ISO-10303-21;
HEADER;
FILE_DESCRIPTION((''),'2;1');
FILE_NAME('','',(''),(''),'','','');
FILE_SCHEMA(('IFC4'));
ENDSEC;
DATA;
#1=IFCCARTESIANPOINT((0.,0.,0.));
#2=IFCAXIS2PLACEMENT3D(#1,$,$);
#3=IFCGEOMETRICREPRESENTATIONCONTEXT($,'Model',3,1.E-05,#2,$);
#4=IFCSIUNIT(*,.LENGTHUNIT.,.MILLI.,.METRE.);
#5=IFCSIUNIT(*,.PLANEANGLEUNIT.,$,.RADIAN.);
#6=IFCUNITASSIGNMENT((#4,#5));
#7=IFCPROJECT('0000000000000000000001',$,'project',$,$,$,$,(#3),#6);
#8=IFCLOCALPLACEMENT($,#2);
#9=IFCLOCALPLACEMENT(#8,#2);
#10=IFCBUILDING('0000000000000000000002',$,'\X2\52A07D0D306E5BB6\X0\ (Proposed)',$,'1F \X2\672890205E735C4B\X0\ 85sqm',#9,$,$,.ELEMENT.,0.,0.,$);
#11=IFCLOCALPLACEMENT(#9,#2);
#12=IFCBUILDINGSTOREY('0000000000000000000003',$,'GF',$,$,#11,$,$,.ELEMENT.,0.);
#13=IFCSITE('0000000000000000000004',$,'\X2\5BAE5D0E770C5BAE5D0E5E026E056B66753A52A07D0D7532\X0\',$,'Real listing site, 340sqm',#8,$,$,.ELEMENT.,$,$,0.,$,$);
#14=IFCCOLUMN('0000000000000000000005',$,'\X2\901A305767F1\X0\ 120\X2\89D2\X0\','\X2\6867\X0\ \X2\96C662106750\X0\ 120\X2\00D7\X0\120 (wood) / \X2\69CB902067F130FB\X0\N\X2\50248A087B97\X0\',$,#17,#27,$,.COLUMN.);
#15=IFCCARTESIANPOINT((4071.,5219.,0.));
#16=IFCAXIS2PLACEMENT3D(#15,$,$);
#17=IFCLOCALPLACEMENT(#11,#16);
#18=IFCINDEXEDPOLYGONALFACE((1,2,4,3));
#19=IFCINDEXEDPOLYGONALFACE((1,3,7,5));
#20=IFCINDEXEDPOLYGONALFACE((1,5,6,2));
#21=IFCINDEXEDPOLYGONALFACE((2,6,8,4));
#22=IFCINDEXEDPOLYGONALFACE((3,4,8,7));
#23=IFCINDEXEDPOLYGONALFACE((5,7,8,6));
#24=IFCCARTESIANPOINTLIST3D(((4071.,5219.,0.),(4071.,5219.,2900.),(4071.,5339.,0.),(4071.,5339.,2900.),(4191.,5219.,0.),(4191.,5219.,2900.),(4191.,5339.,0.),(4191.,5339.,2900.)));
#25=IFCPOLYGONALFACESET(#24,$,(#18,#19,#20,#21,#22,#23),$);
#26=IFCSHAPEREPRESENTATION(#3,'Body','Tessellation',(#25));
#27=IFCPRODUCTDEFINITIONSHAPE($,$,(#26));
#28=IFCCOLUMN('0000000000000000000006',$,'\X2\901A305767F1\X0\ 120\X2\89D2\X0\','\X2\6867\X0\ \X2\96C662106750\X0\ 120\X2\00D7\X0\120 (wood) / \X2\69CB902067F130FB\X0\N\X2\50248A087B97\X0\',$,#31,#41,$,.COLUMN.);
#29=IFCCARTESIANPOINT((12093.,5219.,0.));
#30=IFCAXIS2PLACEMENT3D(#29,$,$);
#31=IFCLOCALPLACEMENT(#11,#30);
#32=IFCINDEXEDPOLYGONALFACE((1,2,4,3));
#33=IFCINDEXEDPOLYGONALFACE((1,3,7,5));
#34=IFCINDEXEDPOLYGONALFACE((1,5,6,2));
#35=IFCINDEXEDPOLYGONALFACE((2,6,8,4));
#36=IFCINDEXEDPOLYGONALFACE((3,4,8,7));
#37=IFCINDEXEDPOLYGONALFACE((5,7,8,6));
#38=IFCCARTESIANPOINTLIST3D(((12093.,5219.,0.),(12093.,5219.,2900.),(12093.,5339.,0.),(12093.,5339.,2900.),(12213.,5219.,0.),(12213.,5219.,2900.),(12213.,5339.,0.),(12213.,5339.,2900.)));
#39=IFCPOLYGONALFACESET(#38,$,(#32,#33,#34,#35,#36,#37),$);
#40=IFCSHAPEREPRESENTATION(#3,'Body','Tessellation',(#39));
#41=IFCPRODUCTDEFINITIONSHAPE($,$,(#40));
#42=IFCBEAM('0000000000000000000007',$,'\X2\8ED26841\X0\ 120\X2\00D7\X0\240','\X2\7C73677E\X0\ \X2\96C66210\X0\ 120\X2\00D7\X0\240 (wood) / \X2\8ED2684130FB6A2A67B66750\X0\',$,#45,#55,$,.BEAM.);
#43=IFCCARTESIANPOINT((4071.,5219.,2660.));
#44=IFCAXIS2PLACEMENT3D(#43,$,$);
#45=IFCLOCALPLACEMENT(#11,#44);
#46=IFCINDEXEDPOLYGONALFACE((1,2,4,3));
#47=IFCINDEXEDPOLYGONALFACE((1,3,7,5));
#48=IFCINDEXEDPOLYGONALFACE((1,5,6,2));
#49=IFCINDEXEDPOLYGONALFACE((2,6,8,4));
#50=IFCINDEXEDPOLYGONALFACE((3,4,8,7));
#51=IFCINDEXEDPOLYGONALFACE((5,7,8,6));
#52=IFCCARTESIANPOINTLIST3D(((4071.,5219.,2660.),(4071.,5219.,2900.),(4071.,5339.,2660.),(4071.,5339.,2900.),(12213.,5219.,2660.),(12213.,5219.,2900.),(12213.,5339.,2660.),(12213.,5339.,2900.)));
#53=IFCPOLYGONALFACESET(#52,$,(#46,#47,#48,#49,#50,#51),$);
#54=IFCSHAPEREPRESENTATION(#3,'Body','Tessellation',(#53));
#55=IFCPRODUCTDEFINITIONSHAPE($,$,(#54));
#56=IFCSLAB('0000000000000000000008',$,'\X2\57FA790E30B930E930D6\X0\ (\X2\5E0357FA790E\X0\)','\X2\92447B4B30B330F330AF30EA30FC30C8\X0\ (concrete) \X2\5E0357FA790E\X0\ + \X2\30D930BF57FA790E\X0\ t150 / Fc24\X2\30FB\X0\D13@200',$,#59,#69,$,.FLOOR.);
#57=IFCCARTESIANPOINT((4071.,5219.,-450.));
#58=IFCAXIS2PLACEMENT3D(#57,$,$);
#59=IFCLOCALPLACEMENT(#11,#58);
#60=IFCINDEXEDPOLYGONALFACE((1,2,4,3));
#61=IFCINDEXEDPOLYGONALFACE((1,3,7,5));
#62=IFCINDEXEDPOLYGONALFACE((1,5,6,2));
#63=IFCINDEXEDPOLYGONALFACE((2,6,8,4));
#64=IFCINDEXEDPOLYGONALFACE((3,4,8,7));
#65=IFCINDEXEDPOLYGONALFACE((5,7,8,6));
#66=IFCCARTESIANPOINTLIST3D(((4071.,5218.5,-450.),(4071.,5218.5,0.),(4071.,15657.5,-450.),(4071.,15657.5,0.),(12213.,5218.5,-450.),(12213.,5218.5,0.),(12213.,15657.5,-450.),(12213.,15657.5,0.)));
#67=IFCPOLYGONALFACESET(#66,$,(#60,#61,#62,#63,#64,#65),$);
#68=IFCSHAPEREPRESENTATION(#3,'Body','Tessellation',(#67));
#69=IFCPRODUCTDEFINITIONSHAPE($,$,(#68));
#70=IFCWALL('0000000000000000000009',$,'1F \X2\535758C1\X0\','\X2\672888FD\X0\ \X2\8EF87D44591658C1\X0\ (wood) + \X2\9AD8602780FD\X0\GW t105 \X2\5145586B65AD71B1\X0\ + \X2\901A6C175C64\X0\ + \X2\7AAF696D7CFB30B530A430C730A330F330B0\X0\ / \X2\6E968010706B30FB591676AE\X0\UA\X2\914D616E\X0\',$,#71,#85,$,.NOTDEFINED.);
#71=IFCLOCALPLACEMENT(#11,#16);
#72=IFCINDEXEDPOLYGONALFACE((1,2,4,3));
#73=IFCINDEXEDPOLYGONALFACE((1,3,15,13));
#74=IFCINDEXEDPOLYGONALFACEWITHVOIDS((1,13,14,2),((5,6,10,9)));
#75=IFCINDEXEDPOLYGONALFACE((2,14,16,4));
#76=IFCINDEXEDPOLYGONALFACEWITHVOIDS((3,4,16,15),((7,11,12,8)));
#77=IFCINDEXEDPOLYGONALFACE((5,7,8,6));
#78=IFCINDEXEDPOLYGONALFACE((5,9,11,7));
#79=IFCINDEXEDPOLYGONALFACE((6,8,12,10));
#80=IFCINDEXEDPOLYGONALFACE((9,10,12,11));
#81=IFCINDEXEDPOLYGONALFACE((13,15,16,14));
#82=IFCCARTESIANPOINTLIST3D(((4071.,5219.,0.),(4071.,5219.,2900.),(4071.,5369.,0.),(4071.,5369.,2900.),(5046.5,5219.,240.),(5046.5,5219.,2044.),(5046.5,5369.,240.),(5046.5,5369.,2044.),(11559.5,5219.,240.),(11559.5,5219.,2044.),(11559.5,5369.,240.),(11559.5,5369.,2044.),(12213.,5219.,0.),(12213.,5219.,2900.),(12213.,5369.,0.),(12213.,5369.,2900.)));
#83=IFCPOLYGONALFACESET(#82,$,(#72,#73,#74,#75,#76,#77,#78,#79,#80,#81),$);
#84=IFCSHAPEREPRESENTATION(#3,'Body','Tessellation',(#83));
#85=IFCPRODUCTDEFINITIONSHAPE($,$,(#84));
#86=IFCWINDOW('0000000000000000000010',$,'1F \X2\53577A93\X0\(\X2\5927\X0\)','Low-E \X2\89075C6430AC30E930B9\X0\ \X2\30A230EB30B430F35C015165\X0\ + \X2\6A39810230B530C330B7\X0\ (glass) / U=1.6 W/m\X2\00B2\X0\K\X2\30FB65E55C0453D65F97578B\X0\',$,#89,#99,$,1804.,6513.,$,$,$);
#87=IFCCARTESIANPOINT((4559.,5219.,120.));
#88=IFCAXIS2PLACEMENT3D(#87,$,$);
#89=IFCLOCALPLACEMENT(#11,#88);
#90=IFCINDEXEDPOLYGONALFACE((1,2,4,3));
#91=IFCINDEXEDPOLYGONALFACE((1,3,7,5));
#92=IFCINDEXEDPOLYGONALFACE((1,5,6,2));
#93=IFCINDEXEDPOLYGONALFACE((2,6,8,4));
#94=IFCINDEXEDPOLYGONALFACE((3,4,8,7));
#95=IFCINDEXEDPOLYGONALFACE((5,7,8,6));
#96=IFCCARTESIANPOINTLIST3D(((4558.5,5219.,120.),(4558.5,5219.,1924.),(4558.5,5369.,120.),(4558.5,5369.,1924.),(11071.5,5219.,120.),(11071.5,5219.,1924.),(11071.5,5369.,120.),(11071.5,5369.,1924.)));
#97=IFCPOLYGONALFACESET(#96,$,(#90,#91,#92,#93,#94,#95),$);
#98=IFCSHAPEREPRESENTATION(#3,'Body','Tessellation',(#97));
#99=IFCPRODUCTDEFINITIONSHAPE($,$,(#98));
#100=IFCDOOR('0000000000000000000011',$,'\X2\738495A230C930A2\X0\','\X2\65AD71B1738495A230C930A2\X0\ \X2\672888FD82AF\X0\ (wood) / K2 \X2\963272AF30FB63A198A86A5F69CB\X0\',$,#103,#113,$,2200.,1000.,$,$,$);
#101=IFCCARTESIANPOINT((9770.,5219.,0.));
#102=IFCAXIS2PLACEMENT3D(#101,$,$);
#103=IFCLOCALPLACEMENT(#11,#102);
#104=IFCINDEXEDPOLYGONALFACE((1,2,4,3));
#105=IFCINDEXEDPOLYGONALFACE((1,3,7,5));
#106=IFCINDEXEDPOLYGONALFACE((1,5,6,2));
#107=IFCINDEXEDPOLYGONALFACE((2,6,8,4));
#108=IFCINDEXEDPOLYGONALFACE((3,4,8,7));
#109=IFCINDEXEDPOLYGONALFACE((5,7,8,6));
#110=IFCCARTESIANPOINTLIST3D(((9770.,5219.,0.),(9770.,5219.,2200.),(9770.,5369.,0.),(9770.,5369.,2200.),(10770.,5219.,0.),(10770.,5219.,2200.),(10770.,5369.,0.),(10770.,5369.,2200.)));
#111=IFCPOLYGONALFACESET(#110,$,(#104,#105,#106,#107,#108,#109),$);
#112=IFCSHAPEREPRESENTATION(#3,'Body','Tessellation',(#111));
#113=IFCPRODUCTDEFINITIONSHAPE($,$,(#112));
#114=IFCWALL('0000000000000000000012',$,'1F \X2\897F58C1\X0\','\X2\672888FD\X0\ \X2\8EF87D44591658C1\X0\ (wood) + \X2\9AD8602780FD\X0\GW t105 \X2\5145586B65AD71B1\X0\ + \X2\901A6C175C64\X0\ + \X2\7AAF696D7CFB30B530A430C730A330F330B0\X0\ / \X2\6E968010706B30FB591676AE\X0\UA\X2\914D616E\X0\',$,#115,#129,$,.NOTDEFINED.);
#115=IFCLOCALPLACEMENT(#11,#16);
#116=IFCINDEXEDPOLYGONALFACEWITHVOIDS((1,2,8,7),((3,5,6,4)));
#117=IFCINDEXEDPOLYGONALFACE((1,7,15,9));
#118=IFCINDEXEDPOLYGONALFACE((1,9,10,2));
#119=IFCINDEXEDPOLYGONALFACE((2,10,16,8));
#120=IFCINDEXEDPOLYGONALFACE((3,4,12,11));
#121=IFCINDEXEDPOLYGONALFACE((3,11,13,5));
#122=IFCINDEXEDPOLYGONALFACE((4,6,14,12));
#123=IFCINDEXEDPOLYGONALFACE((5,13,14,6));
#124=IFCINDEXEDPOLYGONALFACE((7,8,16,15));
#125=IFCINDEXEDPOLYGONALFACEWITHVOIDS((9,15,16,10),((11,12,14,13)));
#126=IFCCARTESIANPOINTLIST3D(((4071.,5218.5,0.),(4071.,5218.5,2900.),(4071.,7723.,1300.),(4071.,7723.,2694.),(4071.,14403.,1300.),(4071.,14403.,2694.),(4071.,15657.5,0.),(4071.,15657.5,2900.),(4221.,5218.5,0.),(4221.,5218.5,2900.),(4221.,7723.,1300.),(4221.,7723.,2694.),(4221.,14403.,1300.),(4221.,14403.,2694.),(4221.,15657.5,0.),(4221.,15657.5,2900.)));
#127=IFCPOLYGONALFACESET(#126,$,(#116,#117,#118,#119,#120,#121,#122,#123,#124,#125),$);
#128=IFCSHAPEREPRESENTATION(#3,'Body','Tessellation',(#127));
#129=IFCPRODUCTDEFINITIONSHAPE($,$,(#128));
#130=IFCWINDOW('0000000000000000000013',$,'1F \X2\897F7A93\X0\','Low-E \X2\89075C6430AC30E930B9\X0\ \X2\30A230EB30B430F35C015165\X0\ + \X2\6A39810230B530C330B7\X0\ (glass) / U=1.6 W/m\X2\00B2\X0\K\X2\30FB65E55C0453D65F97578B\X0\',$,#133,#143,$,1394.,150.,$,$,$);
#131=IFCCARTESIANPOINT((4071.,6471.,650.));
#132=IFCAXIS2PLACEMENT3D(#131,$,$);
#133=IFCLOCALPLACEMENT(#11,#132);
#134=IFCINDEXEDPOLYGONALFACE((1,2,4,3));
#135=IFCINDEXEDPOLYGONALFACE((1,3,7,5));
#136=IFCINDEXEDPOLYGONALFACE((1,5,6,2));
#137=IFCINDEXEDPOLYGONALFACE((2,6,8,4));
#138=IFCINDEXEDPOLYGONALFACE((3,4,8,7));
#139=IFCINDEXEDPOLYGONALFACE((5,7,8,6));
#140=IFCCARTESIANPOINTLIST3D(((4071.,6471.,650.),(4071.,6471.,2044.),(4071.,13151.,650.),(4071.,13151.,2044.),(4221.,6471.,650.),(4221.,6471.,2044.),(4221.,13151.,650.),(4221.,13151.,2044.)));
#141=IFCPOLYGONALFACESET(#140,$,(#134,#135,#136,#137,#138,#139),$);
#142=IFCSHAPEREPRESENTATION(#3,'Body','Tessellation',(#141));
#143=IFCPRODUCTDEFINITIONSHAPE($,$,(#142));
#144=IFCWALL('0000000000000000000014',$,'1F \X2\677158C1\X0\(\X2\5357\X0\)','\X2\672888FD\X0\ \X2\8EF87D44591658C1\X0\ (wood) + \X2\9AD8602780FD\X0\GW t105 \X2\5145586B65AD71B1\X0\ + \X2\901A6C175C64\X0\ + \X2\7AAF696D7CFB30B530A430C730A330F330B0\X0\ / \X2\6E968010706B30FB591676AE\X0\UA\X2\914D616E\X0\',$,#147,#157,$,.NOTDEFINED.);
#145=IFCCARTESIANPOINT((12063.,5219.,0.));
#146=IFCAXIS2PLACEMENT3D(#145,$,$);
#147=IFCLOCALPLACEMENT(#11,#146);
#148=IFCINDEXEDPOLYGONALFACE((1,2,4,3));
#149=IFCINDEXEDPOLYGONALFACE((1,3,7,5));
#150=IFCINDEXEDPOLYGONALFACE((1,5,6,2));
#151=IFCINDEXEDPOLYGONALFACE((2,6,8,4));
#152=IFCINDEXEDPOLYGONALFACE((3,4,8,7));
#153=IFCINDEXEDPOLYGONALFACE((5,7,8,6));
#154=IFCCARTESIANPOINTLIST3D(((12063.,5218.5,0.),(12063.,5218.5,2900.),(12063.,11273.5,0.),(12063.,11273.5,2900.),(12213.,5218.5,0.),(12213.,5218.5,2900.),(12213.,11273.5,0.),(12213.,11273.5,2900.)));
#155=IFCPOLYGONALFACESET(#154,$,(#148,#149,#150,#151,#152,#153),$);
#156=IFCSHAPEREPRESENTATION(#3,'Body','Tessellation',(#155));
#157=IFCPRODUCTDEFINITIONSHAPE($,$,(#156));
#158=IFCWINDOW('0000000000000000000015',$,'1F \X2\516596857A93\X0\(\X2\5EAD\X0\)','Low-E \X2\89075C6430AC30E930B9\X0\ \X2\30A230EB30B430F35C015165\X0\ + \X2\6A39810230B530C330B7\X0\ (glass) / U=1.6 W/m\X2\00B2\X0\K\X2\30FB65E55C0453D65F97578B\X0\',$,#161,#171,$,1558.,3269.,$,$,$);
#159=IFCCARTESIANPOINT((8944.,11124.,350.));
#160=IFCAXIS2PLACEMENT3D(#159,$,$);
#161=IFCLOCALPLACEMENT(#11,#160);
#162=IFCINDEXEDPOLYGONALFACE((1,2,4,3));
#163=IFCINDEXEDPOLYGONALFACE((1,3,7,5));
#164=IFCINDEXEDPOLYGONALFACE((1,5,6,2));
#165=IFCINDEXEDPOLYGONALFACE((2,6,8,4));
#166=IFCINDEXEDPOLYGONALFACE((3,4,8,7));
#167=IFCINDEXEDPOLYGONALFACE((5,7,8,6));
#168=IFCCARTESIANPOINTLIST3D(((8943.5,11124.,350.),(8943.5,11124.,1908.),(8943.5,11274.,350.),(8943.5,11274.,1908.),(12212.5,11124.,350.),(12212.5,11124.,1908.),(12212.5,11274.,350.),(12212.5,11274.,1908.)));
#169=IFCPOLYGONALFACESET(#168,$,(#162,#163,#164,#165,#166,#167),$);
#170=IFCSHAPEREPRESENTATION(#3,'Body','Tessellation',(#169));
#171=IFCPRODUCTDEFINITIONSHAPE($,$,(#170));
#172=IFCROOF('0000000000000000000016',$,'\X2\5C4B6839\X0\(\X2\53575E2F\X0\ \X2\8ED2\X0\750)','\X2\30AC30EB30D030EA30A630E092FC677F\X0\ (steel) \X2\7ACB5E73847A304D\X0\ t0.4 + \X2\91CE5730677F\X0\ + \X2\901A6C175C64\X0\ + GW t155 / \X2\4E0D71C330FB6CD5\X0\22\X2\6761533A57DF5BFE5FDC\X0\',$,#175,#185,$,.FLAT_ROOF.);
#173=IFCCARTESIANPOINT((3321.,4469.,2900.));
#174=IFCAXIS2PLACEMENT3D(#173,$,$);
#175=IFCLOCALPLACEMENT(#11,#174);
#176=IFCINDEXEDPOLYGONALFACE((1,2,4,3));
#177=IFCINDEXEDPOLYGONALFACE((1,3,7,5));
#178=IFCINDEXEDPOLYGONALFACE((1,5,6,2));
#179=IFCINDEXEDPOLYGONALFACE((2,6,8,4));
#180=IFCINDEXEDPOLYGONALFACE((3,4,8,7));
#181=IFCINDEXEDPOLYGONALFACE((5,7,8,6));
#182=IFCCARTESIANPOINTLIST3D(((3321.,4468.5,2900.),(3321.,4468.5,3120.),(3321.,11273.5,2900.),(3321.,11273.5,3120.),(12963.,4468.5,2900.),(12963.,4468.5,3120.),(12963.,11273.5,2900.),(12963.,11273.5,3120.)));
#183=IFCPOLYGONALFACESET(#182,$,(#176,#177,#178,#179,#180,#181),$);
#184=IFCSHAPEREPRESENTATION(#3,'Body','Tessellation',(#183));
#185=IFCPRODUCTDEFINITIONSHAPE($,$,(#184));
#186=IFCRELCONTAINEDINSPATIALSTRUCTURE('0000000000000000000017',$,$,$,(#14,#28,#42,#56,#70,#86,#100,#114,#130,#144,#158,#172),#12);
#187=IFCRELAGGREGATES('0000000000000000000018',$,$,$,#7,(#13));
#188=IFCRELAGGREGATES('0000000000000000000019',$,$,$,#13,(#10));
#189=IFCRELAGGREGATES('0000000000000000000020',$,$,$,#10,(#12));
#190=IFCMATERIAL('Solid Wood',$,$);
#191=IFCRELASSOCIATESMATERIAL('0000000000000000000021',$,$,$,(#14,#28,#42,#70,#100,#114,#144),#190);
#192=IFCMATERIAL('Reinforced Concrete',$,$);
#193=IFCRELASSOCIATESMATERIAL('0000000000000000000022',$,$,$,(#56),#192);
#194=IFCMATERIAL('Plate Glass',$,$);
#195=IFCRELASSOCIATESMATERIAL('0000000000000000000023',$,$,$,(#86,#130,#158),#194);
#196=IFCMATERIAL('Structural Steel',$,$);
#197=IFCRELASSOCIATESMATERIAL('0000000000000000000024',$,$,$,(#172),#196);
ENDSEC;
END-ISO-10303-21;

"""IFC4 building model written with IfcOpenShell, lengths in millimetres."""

from ifc_helpers import new_model, si_unit, frame, frame_2d, origin, place, context, project, spatial, rectangle, extrude, material, element, fill, save


model = new_model("IFC4")

# Units and contexts
model_context = context("Model", 3, precision=1e-05, world=origin())
ifc_project = project(units=[si_unit("LENGTHUNIT", "METRE", prefix="MILLI"), si_unit("PLANEANGLEUNIT", "RADIAN")], contexts=[model_context])

# Site, building, storey
site_placement = place(None, origin())
site = spatial("IfcSite", under=ifc_project, at=site_placement, Name="宮崎県宮崎市清武町加納甲", ObjectType="Real listing site, 340sqm", CompositionType="ELEMENT", RefElevation=0.0)
building_placement = place(site_placement, origin())
building = spatial("IfcBuilding", under=site, at=building_placement, Name="加納の家 (Proposed)", ObjectType="1F 木造平屋 85sqm", CompositionType="ELEMENT", ElevationOfRefHeight=0.0, ElevationOfTerrain=0.0)
storey_placement = place(building_placement, origin())
storey = spatial("IfcBuildingStorey", under=building, at=storey_placement, Name="GF", CompositionType="ELEMENT", Elevation=0.0)

# Columns
ifc_material_1 = material(Name="Solid Wood")
column_1_placement = place(storey_placement, frame((4071.0, 5219.0, 0.0)))
element("IfcColumn", 1, at=column_1_placement, inside=storey, material=ifc_material_1, Name="通し柱 120角", Description="桧 集成材 120×120 (wood) / 構造柱・N値計算", PredefinedType="COLUMN", context=model_context, shape_type="SweptSolid", body=[
    extrude(rectangle(XDim=120.0, YDim=120.0, at=frame_2d((60.0, 60.0))), frame((4071.0, 5219.0, 0.0)), (0.0, 0.0, 1.0), 2900.0),
])
column_2_placement = place(storey_placement, frame((12093.0, 5219.0, 0.0)))
element("IfcColumn", 2, at=column_2_placement, inside=storey, material=ifc_material_1, Name="通し柱 120角", Description="桧 集成材 120×120 (wood) / 構造柱・N値計算", PredefinedType="COLUMN", context=model_context, shape_type="SweptSolid", body=[
    extrude(rectangle(XDim=120.0, YDim=120.0, at=frame_2d((60.0, 60.0))), frame((12093.0, 5219.0, 0.0)), (0.0, 0.0, 1.0), 2900.0),
])

# Beam
beam_1_placement = place(storey_placement, frame((4071.0, 5219.0, 2660.0)))
element("IfcBeam", 3, at=beam_1_placement, inside=storey, material=ifc_material_1, Name="軒桁 120×240", Description="米松 集成 120×240 (wood) / 軒桁・横架材", PredefinedType="BEAM", context=model_context, shape_type="SweptSolid", body=[
    extrude(rectangle(XDim=8142.0, YDim=120.0, at=frame_2d((4071.0, 60.0))), frame((4071.0, 5219.0, 2660.0)), (0.0, 0.0, 1.0), 240.0),
])

# Slab
ifc_material_2 = material(Name="Reinforced Concrete")
slab_1_placement = place(storey_placement, frame((4071.0, 5219.0, -450.0)))
element("IfcSlab", 4, at=slab_1_placement, inside=storey, material=ifc_material_2, Name="基礎スラブ (布基礎)", Description="鉄筋コンクリート (concrete) 布基礎 + ベタ基礎 t150 / Fc24・D13@200", PredefinedType="FLOOR", context=model_context, shape_type="SweptSolid", body=[
    extrude(rectangle(XDim=8142.0, YDim=10439.0, at=frame_2d((4071.0, 5219.0))), frame((4071.0, 5219.0, -450.0)), (0.0, 0.0, 1.0), 450.0),
])

# Wall, openings, window, door
wall_1_placement = place(storey_placement, frame((4071.0, 5219.0, 0.0)))
wall_1 = element("IfcWall", 5, at=wall_1_placement, inside=storey, material=ifc_material_1, Name="1F 南壁", Description="木製 軸組外壁 (wood) + 高性能GW t105 充填断熱 + 通気層 + 窯業系サイディング / 準耐火・外皮UA配慮", PredefinedType="NOTDEFINED", context=model_context, shape_type="SweptSolid", body=[
    extrude(rectangle(XDim=8142.0, YDim=150.0, at=frame_2d((4071.0, 75.0))), frame((4071.0, 5219.0, 0.0)), (0.0, 0.0, 1.0), 2900.0),
])
opening_1_placement = place(storey_placement, frame((4559.0, 5219.0, 120.0)))
opening_1 = element("IfcOpeningElement", 6, at=opening_1_placement, cuts=wall_1, PredefinedType="NOTDEFINED", context=model_context, shape_type="SweptSolid", body=[
    extrude(rectangle(XDim=6513.0, YDim=150.0, at=frame_2d((3256.0, 75.0))), frame((4559.0, 5219.0, 120.0)), (0.0, 0.0, 1.0), 1804.0),
])
opening_2_placement = place(storey_placement, frame((9770.0, 5219.0, 0.0)))
opening_2 = element("IfcOpeningElement", 7, at=opening_2_placement, cuts=wall_1, PredefinedType="NOTDEFINED", context=model_context, shape_type="SweptSolid", body=[
    extrude(rectangle(XDim=1000.0, YDim=150.0, at=frame_2d((500.0, 75.0))), frame((9770.0, 5219.0, 0.0)), (0.0, 0.0, 1.0), 2200.0),
])
ifc_material_3 = material(Name="Plate Glass")
window_1_placement = place(storey_placement, frame((4559.0, 5219.0, 120.0)))
window_1 = element("IfcWindow", 8, at=window_1_placement, inside=storey, material=ifc_material_3, Name="1F 南窓(大)", Description="Low-E 複層ガラス アルゴン封入 + 樹脂サッシ (glass) / U=1.6 W/m²K・日射取得型", OverallHeight=1804.0, OverallWidth=6513.0, context=model_context, shape_type="SweptSolid", body=[
    extrude(rectangle(XDim=6513.0, YDim=150.0, at=frame_2d((3256.0, 75.0))), frame((4559.0, 5219.0, 120.0)), (0.0, 0.0, 1.0), 1804.0),
])
fill(opening_1, window_1)
door_1_placement = place(storey_placement, frame((9770.0, 5219.0, 0.0)))
door_1 = element("IfcDoor", 9, at=door_1_placement, inside=storey, material=ifc_material_1, Name="玄関ドア", Description="断熱玄関ドア 木製芯 (wood) / K2 防犯・採風機構", OverallHeight=2200.0, OverallWidth=1000.0, context=model_context, shape_type="SweptSolid", body=[
    extrude(rectangle(XDim=1000.0, YDim=150.0, at=frame_2d((500.0, 75.0))), frame((9770.0, 5219.0, 0.0)), (0.0, 0.0, 1.0), 2200.0),
])
fill(opening_2, door_1)

# Walls, openings, windows
wall_2_placement = place(storey_placement, frame((4071.0, 5219.0, 0.0)))
wall_2 = element("IfcWall", 10, at=wall_2_placement, inside=storey, material=ifc_material_1, Name="1F 西壁", Description="木製 軸組外壁 (wood) + 高性能GW t105 充填断熱 + 通気層 + 窯業系サイディング / 準耐火・外皮UA配慮", PredefinedType="NOTDEFINED", context=model_context, shape_type="SweptSolid", body=[
    extrude(rectangle(XDim=150.0, YDim=10439.0, at=frame_2d((75.0, 5219.0))), frame((4071.0, 5219.0, 0.0)), (0.0, 0.0, 1.0), 2900.0),
])
opening_3_placement = place(storey_placement, frame((4071.0, 6471.0, 650.0)))
opening_3 = element("IfcOpeningElement", 11, at=opening_3_placement, cuts=wall_2, PredefinedType="NOTDEFINED", context=model_context, shape_type="SweptSolid", body=[
    extrude(rectangle(XDim=150.0, YDim=6680.0, at=frame_2d((75.0, 3340.0))), frame((4071.0, 6471.0, 650.0)), (0.0, 0.0, 1.0), 1394.0),
])
window_2_placement = place(storey_placement, frame((4071.0, 6471.0, 650.0)))
window_2 = element("IfcWindow", 12, at=window_2_placement, inside=storey, material=ifc_material_3, Name="1F 西窓", Description="Low-E 複層ガラス アルゴン封入 + 樹脂サッシ (glass) / U=1.6 W/m²K・日射取得型", OverallHeight=1394.0, OverallWidth=150.0, context=model_context, shape_type="SweptSolid", body=[
    extrude(rectangle(XDim=150.0, YDim=6680.0, at=frame_2d((75.0, 3340.0))), frame((4071.0, 6471.0, 650.0)), (0.0, 0.0, 1.0), 1394.0),
])
fill(opening_3, window_2)
wall_3_placement = place(storey_placement, frame((12063.0, 5219.0, 0.0)))
wall_3 = element("IfcWall", 13, at=wall_3_placement, inside=storey, material=ifc_material_1, Name="1F 東壁(南)", Description="木製 軸組外壁 (wood) + 高性能GW t105 充填断熱 + 通気層 + 窯業系サイディング / 準耐火・外皮UA配慮", PredefinedType="NOTDEFINED", context=model_context, shape_type="SweptSolid", body=[
    extrude(rectangle(XDim=150.0, YDim=6055.0, at=frame_2d((75.0, 3027.0))), frame((12063.0, 5219.0, 0.0)), (0.0, 0.0, 1.0), 2900.0),
])
opening_4_placement = place(storey_placement, frame((8944.0, 11124.0, 350.0)))
opening_4 = element("IfcOpeningElement", 14, at=opening_4_placement, cuts=wall_3, PredefinedType="NOTDEFINED", context=model_context, shape_type="SweptSolid", body=[
    extrude(rectangle(XDim=3269.0, YDim=150.0, at=frame_2d((1634.0, 75.0))), frame((8944.0, 11124.0, 350.0)), (0.0, 0.0, 1.0), 1558.0),
])
window_3_placement = place(storey_placement, frame((8944.0, 11124.0, 350.0)))
window_3 = element("IfcWindow", 15, at=window_3_placement, inside=storey, material=ifc_material_3, Name="1F 入隅窓(庭)", Description="Low-E 複層ガラス アルゴン封入 + 樹脂サッシ (glass) / U=1.6 W/m²K・日射取得型", OverallHeight=1558.0, OverallWidth=3269.0, context=model_context, shape_type="SweptSolid", body=[
    extrude(rectangle(XDim=3269.0, YDim=150.0, at=frame_2d((1634.0, 75.0))), frame((8944.0, 11124.0, 350.0)), (0.0, 0.0, 1.0), 1558.0),
])
fill(opening_4, window_3)

# Roof
ifc_material_4 = material(Name="Structural Steel")
roof_placement = place(storey_placement, frame((3321.0, 4469.0, 2900.0)))
element("IfcRoof", 16, at=roof_placement, inside=storey, material=ifc_material_4, Name="屋根(南帯 軒750)", Description="ガルバリウム鋼板 (steel) 立平葺き t0.4 + 野地板 + 通気層 + GW t155 / 不燃・法22条区域対応", PredefinedType="FLAT_ROOF", context=model_context, shape_type="SweptSolid", body=[
    extrude(rectangle(XDim=9642.0, YDim=6805.0, at=frame_2d((4821.0, 3402.0))), frame((3321.0, 4469.0, 2900.0)), (0.0, 0.0, 1.0), 220.0),
])

save(model, "model.ifc")
